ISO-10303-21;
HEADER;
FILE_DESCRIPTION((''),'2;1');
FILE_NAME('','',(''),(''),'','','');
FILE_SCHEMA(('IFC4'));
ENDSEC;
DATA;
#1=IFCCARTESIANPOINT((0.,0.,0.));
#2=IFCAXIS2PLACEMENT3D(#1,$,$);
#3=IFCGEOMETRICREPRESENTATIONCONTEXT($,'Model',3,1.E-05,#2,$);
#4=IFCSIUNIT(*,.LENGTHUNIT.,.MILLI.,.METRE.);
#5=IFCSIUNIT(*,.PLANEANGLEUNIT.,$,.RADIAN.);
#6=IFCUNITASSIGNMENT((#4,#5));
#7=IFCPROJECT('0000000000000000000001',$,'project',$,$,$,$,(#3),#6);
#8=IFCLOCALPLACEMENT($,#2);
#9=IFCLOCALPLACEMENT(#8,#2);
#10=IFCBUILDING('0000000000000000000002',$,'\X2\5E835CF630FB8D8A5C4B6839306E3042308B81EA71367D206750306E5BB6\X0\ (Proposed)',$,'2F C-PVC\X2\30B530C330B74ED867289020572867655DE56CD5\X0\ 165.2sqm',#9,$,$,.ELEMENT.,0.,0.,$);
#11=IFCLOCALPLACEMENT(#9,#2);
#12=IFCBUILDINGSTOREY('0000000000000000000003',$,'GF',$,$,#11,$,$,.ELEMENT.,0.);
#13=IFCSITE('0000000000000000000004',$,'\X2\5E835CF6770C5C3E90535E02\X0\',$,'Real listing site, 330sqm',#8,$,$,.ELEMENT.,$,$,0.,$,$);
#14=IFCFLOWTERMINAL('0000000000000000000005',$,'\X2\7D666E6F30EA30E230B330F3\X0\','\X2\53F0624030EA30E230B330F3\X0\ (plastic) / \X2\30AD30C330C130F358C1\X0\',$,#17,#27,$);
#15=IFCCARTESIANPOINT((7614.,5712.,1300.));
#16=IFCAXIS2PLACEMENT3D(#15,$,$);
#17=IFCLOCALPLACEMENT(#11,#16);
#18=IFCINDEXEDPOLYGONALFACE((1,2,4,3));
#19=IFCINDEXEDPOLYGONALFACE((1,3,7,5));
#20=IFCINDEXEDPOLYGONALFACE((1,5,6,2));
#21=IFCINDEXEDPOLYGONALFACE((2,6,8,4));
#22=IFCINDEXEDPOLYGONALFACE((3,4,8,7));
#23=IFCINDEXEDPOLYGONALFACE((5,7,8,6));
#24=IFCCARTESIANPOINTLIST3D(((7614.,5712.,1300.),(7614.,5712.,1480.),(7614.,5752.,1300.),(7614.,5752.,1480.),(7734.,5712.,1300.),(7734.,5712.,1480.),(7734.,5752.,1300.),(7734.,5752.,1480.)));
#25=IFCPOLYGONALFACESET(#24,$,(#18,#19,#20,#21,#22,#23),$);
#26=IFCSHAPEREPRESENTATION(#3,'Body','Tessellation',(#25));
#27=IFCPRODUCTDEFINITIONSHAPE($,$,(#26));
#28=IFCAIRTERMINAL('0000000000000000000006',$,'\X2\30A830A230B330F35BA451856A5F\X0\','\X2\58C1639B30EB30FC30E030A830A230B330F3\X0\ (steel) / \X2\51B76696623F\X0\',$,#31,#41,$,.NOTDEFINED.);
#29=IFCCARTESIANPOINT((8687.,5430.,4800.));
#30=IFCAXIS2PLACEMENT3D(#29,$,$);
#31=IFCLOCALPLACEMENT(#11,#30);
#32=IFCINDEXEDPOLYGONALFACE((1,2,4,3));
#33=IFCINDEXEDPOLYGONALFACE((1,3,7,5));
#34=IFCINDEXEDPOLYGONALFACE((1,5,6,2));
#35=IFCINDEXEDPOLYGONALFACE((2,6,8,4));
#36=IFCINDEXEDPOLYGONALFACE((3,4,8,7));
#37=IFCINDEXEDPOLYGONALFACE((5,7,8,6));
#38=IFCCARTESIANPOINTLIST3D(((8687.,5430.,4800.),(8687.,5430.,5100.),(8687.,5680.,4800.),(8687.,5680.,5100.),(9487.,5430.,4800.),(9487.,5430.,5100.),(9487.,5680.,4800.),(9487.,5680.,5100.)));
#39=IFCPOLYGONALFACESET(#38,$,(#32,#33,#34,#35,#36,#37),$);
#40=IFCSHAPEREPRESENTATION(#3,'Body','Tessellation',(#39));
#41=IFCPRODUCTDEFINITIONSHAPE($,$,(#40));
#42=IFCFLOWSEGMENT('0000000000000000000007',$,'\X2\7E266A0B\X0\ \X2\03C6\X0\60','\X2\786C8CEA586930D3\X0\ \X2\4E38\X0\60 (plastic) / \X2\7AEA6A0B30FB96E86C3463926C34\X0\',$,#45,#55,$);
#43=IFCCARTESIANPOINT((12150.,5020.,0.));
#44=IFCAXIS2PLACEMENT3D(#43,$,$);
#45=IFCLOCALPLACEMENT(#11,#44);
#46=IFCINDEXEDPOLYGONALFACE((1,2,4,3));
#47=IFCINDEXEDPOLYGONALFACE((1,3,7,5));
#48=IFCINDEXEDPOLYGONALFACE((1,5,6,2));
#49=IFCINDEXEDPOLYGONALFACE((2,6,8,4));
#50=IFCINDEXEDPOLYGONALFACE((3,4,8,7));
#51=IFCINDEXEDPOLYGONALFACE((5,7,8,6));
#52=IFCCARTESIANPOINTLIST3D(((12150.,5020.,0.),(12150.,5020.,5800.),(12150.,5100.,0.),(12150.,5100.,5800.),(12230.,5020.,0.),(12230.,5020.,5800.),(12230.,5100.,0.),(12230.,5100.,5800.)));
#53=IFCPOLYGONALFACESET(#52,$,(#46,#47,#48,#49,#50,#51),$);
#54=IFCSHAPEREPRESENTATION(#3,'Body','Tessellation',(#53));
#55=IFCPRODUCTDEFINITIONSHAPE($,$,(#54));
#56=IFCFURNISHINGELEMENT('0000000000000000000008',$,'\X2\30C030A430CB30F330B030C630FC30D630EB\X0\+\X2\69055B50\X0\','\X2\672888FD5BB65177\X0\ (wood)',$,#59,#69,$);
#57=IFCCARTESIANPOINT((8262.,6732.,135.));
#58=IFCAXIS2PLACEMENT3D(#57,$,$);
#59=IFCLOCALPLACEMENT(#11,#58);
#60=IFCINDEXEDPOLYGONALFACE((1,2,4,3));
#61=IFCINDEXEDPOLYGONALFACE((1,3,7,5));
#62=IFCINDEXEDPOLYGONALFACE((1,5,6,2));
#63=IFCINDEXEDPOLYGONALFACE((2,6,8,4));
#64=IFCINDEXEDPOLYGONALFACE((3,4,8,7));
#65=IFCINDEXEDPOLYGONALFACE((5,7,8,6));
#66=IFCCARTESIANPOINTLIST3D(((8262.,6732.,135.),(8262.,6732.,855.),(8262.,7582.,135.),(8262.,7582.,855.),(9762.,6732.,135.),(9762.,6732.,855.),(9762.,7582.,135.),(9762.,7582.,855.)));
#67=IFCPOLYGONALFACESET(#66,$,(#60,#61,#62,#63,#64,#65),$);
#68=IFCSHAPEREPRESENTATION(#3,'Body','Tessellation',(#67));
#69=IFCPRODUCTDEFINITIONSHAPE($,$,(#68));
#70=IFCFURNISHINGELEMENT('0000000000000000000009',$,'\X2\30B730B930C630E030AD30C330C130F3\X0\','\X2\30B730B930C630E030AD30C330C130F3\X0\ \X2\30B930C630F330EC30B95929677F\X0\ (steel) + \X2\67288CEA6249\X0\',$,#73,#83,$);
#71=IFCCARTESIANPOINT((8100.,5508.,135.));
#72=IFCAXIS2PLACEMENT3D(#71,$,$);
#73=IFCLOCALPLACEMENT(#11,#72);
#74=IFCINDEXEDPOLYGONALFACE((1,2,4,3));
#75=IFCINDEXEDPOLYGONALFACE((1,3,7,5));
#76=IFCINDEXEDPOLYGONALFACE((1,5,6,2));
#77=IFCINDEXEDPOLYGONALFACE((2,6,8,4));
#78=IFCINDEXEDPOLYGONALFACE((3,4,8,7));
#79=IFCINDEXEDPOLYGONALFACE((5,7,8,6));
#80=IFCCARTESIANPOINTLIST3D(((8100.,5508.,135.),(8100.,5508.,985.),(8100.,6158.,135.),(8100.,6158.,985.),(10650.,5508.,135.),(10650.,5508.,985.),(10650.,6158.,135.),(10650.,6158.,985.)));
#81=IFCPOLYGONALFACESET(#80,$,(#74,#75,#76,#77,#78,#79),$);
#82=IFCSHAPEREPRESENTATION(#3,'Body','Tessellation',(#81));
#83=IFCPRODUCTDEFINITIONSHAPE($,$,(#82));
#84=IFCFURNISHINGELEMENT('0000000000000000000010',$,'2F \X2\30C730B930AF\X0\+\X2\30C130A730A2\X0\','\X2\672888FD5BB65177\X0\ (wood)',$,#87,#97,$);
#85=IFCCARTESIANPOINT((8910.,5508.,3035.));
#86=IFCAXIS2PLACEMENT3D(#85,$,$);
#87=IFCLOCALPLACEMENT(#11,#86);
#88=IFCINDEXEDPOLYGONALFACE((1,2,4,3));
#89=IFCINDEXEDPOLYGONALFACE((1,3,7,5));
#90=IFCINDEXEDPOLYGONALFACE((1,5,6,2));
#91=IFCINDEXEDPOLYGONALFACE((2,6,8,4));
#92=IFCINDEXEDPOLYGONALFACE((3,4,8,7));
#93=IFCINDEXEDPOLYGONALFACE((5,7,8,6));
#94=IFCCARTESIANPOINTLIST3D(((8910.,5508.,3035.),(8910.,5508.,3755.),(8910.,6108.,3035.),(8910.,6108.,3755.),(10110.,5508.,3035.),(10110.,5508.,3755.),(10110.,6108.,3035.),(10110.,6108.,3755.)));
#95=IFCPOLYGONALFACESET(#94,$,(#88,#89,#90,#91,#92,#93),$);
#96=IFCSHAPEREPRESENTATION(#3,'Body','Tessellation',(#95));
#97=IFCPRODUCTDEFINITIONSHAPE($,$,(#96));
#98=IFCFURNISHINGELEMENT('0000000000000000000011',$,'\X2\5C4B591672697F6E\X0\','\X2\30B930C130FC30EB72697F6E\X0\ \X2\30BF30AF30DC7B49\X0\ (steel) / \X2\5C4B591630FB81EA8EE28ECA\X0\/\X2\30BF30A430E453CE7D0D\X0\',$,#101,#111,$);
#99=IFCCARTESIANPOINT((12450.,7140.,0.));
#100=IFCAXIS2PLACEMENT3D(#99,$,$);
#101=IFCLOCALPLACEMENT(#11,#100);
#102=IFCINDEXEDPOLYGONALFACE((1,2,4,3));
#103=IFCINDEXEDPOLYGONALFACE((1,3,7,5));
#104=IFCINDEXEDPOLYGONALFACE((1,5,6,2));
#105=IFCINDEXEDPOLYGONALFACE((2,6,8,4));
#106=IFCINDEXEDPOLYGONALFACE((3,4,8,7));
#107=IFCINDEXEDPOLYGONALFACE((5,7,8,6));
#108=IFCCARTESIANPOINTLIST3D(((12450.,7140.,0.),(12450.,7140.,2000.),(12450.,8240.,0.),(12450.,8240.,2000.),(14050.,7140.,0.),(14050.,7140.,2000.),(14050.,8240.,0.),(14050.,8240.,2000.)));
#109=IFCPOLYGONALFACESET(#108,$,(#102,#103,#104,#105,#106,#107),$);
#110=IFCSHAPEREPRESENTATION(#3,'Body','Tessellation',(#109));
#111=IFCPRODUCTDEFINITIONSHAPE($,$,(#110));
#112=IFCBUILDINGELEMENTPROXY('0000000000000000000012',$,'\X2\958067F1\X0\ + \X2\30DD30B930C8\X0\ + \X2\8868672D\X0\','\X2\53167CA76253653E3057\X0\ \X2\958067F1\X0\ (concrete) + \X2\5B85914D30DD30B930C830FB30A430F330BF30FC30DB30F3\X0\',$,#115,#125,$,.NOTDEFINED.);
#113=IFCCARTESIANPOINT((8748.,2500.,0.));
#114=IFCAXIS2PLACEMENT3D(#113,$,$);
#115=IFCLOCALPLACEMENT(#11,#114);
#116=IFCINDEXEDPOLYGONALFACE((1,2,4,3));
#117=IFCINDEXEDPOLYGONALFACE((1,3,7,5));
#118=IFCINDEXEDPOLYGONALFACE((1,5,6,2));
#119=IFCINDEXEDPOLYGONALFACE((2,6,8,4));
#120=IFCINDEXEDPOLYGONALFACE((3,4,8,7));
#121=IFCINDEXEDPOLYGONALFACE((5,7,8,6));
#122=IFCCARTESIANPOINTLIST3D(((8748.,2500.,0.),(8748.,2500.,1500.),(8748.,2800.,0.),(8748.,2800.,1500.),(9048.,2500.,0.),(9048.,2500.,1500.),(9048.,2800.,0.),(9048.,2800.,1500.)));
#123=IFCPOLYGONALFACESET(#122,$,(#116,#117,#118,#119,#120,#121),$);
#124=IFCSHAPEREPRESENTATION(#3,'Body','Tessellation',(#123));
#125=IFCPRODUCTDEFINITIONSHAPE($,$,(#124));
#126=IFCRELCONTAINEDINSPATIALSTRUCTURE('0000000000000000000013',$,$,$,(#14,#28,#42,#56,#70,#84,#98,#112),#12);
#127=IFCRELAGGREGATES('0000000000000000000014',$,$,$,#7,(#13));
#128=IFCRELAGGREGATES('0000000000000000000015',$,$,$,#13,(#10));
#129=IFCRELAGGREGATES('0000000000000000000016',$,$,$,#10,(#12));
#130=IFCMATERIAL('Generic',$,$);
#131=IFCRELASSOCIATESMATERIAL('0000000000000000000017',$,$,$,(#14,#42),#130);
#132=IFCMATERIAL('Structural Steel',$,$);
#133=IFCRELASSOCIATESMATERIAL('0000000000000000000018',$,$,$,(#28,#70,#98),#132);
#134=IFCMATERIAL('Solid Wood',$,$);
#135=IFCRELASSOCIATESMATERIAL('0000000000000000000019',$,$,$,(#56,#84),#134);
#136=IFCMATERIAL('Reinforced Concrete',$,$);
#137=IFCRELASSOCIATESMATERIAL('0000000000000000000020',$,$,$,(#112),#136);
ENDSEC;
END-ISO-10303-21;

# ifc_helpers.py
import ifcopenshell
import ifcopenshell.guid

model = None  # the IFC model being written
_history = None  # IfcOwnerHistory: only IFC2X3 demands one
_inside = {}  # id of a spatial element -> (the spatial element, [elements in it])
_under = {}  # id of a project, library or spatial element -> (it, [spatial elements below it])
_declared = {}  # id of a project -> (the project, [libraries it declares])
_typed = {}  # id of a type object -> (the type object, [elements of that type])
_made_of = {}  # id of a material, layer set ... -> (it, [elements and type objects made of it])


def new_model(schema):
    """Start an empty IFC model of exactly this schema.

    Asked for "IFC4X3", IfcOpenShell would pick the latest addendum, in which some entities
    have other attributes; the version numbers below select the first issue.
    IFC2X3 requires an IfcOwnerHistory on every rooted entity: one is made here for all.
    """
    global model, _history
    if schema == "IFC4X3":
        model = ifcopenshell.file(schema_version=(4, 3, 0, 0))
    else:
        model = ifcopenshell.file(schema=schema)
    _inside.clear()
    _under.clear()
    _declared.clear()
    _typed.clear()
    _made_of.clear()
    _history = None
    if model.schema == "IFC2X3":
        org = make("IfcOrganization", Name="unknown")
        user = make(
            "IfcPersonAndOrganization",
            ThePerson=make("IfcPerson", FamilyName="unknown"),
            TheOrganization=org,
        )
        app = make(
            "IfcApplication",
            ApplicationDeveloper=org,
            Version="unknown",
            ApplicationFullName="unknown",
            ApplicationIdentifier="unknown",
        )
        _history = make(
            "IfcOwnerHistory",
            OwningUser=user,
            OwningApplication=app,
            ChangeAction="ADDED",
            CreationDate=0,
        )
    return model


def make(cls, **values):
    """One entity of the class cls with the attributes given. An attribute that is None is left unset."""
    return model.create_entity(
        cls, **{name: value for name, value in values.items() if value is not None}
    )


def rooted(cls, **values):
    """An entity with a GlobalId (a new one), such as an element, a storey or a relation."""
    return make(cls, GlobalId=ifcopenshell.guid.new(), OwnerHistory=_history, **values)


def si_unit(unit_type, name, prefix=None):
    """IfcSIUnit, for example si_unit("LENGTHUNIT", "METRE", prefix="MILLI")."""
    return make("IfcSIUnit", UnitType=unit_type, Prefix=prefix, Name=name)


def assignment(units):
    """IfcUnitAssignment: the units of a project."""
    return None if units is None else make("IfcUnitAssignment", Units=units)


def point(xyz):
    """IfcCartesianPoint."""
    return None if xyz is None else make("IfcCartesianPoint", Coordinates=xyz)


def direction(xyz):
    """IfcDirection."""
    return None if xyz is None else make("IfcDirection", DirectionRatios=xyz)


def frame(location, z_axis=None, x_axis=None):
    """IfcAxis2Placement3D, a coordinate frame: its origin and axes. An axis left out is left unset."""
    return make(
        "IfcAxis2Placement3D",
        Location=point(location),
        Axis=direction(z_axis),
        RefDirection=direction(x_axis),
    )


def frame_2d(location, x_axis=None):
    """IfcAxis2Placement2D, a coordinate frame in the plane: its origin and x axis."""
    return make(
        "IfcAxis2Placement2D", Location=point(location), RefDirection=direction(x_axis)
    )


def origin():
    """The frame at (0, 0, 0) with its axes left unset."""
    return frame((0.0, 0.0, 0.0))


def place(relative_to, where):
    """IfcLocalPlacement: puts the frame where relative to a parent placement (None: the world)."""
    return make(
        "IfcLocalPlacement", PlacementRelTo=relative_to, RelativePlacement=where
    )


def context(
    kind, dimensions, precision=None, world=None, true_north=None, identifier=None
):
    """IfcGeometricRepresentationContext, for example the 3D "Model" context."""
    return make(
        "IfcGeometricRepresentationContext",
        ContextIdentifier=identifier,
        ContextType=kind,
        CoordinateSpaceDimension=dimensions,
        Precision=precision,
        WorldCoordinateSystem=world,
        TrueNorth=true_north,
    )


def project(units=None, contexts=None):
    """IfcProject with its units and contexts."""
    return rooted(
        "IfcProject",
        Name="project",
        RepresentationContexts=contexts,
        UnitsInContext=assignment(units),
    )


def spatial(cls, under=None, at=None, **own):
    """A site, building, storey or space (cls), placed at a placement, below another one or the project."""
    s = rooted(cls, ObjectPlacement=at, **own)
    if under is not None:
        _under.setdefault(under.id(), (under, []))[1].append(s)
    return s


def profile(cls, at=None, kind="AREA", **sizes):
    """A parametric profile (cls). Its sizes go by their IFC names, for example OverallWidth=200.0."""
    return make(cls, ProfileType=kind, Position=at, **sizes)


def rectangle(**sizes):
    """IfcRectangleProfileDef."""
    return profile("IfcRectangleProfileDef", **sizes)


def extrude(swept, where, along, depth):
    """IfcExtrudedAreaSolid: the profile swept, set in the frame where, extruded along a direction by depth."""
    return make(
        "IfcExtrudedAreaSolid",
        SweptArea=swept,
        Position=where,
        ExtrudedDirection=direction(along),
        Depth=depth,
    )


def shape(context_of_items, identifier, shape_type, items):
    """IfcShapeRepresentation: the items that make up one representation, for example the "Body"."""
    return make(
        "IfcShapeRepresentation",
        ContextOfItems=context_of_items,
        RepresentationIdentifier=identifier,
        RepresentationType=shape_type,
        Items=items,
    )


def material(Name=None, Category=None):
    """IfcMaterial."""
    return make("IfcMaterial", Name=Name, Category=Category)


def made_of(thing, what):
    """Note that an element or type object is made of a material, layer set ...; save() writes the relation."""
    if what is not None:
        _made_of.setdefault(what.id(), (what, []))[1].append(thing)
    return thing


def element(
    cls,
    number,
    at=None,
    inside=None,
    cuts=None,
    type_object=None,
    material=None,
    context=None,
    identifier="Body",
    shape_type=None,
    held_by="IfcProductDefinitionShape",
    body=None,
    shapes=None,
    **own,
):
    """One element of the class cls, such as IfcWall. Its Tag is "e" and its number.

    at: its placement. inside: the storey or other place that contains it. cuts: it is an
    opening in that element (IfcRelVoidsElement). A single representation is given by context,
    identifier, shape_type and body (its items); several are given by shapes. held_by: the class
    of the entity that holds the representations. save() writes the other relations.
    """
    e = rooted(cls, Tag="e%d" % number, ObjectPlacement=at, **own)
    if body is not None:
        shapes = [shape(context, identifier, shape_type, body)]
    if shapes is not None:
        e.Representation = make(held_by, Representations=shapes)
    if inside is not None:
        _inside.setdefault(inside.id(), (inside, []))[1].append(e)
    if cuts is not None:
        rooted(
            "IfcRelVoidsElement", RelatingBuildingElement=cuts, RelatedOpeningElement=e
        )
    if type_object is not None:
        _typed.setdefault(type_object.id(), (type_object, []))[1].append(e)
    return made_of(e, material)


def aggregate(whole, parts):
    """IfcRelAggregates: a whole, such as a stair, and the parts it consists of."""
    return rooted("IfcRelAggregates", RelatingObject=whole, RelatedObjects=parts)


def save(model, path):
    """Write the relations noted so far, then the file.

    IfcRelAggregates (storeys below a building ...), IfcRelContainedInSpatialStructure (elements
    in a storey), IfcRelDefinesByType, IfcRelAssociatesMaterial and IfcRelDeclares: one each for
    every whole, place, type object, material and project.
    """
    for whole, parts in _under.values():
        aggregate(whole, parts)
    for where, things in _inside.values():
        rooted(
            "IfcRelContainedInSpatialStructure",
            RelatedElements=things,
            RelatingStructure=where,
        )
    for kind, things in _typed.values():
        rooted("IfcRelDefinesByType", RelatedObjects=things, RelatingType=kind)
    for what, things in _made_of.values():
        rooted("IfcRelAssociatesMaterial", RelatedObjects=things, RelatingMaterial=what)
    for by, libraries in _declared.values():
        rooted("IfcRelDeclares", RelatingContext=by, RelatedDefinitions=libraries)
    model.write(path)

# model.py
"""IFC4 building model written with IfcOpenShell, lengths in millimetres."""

from ifc_helpers import new_model, si_unit, frame, frame_2d, origin, place, context, project, spatial, rectangle, extrude, material, element, save


model = new_model("IFC4")

# Units and contexts
model_context = context("Model", 3, precision=1e-05, world=origin())
ifc_project = project(units=[si_unit("LENGTHUNIT", "METRE", prefix="MILLI"), si_unit("PLANEANGLEUNIT", "RADIAN")], contexts=[model_context])

# Site, building, storey
site_placement = place(None, origin())
site = spatial("IfcSite", under=ifc_project, at=site_placement, Name="広島県尾道市", ObjectType="Real listing site, 330sqm", CompositionType="ELEMENT", RefElevation=0.0)
building_placement = place(site_placement, origin())
building = spatial("IfcBuilding", under=site, at=building_placement, Name="広島・越屋根のある自然素材の家 (Proposed)", ObjectType="2F C-PVCサッシ付木造在来工法 165.2sqm", CompositionType="ELEMENT", ElevationOfRefHeight=0.0, ElevationOfTerrain=0.0)
storey_placement = place(building_placement, origin())
storey = spatial("IfcBuildingStorey", under=building, at=storey_placement, Name="GF", CompositionType="ELEMENT", Elevation=0.0)

# Shared definitions
ifc_material_1 = material(Name="Solid Wood")

# Shared definitions
ifc_material_2 = material(Name="Reinforced Concrete")

# Shared definitions
ifc_material_3 = material(Name="Structural Steel")

# Flow terminal
ifc_material_4 = material(Name="Generic")
flow_terminal_1_placement = place(storey_placement, frame((7614.0, 5712.0, 1300.0)))
element("IfcFlowTerminal", 1, at=flow_terminal_1_placement, inside=storey, material=ifc_material_4, Name="給湯リモコン", Description="台所リモコン (plastic) / キッチン壁", context=model_context, shape_type="SweptSolid", body=[
    extrude(rectangle(XDim=120.0, YDim=40.0, at=frame_2d((60.0, 20.0))), frame((7614.0, 5712.0, 1300.0)), (0.0, 0.0, 1.0), 180.0),
])

# Air terminal
air_terminal_placement = place(storey_placement, frame((8687.0, 5430.0, 4800.0)))
element("IfcAirTerminal", 2, at=air_terminal_placement, inside=storey, material=ifc_material_3, Name="エアコン室内機", Description="壁掛ルームエアコン (steel) / 冷暖房", PredefinedType="NOTDEFINED", context=model_context, shape_type="SweptSolid", body=[
    extrude(rectangle(XDim=800.0, YDim=250.0, at=frame_2d((400.0, 125.0))), frame((8687.0, 5430.0, 4800.0)), (0.0, 0.0, 1.0), 300.0),
])

# Flow segment
flow_segment_placement = place(storey_placement, frame((12150.0, 5020.0, 0.0)))
element("IfcFlowSegment", 3, at=flow_segment_placement, inside=storey, material=ifc_material_4, Name="縦樋 φ60", Description="硬質塩ビ 丸60 (plastic) / 竪樋・雨水排水", context=model_context, shape_type="SweptSolid", body=[
    extrude(rectangle(XDim=80.0, YDim=80.0, at=frame_2d((40.0, 40.0))), frame((12150.0, 5020.0, 0.0)), (0.0, 0.0, 1.0), 5800.0),
])

# Furnishing elements
furnishing_1_placement = place(storey_placement, frame((8262.0, 6732.0, 135.0)))
element("IfcFurnishingElement", 4, at=furnishing_1_placement, inside=storey, material=ifc_material_1, Name="ダイニングテーブル+椅子", Description="木製家具 (wood)", context=model_context, shape_type="SweptSolid", body=[
    extrude(rectangle(XDim=1500.0, YDim=850.0, at=frame_2d((750.0, 425.0))), frame((8262.0, 6732.0, 135.0)), (0.0, 0.0, 1.0), 720.0),
])
furnishing_2_placement = place(storey_placement, frame((8100.0, 5508.0, 135.0)))
element("IfcFurnishingElement", 5, at=furnishing_2_placement, inside=storey, material=ifc_material_3, Name="システムキッチン", Description="システムキッチン ステンレス天板 (steel) + 木質扉", context=model_context, shape_type="SweptSolid", body=[
    extrude(rectangle(XDim=2550.0, YDim=650.0, at=frame_2d((1275.0, 325.0))), frame((8100.0, 5508.0, 135.0)), (0.0, 0.0, 1.0), 850.0),
])
furnishing_3_placement = place(storey_placement, frame((8910.0, 5508.0, 3035.0)))
element("IfcFurnishingElement", 6, at=furnishing_3_placement, inside=storey, material=ifc_material_1, Name="2F デスク+チェア", Description="木製家具 (wood)", context=model_context, shape_type="SweptSolid", body=[
    extrude(rectangle(XDim=1200.0, YDim=600.0, at=frame_2d((600.0, 300.0))), frame((8910.0, 5508.0, 3035.0)), (0.0, 0.0, 1.0), 720.0),
])
furnishing_4_placement = place(storey_placement, frame((12450.0, 7140.0, 0.0)))
element("IfcFurnishingElement", 7, at=furnishing_4_placement, inside=storey, material=ifc_material_3, Name="屋外物置", Description="スチール物置 タクボ等 (steel) / 屋外・自転車/タイヤ収納", context=model_context, shape_type="SweptSolid", body=[
    extrude(rectangle(XDim=1600.0, YDim=1100.0, at=frame_2d((800.0, 550.0))), frame((12450.0, 7140.0, 0.0)), (0.0, 0.0, 1.0), 2000.0),
])

# Building element proxy
proxy_placement = place(storey_placement, frame((8748.0, 2500.0, 0.0)))
element("IfcBuildingElementProxy", 8, at=proxy_placement, inside=storey, material=ifc_material_2, Name="門柱 + ポスト + 表札", Description="化粧打放し 門柱 (concrete) + 宅配ポスト・インターホン", PredefinedType="NOTDEFINED", context=model_context, shape_type="SweptSolid", body=[
    extrude(rectangle(XDim=300.0, YDim=300.0, at=frame_2d((150.0, 150.0))), frame((8748.0, 2500.0, 0.0)), (0.0, 0.0, 1.0), 1500.0),
])

save(model, "model.ifc")
